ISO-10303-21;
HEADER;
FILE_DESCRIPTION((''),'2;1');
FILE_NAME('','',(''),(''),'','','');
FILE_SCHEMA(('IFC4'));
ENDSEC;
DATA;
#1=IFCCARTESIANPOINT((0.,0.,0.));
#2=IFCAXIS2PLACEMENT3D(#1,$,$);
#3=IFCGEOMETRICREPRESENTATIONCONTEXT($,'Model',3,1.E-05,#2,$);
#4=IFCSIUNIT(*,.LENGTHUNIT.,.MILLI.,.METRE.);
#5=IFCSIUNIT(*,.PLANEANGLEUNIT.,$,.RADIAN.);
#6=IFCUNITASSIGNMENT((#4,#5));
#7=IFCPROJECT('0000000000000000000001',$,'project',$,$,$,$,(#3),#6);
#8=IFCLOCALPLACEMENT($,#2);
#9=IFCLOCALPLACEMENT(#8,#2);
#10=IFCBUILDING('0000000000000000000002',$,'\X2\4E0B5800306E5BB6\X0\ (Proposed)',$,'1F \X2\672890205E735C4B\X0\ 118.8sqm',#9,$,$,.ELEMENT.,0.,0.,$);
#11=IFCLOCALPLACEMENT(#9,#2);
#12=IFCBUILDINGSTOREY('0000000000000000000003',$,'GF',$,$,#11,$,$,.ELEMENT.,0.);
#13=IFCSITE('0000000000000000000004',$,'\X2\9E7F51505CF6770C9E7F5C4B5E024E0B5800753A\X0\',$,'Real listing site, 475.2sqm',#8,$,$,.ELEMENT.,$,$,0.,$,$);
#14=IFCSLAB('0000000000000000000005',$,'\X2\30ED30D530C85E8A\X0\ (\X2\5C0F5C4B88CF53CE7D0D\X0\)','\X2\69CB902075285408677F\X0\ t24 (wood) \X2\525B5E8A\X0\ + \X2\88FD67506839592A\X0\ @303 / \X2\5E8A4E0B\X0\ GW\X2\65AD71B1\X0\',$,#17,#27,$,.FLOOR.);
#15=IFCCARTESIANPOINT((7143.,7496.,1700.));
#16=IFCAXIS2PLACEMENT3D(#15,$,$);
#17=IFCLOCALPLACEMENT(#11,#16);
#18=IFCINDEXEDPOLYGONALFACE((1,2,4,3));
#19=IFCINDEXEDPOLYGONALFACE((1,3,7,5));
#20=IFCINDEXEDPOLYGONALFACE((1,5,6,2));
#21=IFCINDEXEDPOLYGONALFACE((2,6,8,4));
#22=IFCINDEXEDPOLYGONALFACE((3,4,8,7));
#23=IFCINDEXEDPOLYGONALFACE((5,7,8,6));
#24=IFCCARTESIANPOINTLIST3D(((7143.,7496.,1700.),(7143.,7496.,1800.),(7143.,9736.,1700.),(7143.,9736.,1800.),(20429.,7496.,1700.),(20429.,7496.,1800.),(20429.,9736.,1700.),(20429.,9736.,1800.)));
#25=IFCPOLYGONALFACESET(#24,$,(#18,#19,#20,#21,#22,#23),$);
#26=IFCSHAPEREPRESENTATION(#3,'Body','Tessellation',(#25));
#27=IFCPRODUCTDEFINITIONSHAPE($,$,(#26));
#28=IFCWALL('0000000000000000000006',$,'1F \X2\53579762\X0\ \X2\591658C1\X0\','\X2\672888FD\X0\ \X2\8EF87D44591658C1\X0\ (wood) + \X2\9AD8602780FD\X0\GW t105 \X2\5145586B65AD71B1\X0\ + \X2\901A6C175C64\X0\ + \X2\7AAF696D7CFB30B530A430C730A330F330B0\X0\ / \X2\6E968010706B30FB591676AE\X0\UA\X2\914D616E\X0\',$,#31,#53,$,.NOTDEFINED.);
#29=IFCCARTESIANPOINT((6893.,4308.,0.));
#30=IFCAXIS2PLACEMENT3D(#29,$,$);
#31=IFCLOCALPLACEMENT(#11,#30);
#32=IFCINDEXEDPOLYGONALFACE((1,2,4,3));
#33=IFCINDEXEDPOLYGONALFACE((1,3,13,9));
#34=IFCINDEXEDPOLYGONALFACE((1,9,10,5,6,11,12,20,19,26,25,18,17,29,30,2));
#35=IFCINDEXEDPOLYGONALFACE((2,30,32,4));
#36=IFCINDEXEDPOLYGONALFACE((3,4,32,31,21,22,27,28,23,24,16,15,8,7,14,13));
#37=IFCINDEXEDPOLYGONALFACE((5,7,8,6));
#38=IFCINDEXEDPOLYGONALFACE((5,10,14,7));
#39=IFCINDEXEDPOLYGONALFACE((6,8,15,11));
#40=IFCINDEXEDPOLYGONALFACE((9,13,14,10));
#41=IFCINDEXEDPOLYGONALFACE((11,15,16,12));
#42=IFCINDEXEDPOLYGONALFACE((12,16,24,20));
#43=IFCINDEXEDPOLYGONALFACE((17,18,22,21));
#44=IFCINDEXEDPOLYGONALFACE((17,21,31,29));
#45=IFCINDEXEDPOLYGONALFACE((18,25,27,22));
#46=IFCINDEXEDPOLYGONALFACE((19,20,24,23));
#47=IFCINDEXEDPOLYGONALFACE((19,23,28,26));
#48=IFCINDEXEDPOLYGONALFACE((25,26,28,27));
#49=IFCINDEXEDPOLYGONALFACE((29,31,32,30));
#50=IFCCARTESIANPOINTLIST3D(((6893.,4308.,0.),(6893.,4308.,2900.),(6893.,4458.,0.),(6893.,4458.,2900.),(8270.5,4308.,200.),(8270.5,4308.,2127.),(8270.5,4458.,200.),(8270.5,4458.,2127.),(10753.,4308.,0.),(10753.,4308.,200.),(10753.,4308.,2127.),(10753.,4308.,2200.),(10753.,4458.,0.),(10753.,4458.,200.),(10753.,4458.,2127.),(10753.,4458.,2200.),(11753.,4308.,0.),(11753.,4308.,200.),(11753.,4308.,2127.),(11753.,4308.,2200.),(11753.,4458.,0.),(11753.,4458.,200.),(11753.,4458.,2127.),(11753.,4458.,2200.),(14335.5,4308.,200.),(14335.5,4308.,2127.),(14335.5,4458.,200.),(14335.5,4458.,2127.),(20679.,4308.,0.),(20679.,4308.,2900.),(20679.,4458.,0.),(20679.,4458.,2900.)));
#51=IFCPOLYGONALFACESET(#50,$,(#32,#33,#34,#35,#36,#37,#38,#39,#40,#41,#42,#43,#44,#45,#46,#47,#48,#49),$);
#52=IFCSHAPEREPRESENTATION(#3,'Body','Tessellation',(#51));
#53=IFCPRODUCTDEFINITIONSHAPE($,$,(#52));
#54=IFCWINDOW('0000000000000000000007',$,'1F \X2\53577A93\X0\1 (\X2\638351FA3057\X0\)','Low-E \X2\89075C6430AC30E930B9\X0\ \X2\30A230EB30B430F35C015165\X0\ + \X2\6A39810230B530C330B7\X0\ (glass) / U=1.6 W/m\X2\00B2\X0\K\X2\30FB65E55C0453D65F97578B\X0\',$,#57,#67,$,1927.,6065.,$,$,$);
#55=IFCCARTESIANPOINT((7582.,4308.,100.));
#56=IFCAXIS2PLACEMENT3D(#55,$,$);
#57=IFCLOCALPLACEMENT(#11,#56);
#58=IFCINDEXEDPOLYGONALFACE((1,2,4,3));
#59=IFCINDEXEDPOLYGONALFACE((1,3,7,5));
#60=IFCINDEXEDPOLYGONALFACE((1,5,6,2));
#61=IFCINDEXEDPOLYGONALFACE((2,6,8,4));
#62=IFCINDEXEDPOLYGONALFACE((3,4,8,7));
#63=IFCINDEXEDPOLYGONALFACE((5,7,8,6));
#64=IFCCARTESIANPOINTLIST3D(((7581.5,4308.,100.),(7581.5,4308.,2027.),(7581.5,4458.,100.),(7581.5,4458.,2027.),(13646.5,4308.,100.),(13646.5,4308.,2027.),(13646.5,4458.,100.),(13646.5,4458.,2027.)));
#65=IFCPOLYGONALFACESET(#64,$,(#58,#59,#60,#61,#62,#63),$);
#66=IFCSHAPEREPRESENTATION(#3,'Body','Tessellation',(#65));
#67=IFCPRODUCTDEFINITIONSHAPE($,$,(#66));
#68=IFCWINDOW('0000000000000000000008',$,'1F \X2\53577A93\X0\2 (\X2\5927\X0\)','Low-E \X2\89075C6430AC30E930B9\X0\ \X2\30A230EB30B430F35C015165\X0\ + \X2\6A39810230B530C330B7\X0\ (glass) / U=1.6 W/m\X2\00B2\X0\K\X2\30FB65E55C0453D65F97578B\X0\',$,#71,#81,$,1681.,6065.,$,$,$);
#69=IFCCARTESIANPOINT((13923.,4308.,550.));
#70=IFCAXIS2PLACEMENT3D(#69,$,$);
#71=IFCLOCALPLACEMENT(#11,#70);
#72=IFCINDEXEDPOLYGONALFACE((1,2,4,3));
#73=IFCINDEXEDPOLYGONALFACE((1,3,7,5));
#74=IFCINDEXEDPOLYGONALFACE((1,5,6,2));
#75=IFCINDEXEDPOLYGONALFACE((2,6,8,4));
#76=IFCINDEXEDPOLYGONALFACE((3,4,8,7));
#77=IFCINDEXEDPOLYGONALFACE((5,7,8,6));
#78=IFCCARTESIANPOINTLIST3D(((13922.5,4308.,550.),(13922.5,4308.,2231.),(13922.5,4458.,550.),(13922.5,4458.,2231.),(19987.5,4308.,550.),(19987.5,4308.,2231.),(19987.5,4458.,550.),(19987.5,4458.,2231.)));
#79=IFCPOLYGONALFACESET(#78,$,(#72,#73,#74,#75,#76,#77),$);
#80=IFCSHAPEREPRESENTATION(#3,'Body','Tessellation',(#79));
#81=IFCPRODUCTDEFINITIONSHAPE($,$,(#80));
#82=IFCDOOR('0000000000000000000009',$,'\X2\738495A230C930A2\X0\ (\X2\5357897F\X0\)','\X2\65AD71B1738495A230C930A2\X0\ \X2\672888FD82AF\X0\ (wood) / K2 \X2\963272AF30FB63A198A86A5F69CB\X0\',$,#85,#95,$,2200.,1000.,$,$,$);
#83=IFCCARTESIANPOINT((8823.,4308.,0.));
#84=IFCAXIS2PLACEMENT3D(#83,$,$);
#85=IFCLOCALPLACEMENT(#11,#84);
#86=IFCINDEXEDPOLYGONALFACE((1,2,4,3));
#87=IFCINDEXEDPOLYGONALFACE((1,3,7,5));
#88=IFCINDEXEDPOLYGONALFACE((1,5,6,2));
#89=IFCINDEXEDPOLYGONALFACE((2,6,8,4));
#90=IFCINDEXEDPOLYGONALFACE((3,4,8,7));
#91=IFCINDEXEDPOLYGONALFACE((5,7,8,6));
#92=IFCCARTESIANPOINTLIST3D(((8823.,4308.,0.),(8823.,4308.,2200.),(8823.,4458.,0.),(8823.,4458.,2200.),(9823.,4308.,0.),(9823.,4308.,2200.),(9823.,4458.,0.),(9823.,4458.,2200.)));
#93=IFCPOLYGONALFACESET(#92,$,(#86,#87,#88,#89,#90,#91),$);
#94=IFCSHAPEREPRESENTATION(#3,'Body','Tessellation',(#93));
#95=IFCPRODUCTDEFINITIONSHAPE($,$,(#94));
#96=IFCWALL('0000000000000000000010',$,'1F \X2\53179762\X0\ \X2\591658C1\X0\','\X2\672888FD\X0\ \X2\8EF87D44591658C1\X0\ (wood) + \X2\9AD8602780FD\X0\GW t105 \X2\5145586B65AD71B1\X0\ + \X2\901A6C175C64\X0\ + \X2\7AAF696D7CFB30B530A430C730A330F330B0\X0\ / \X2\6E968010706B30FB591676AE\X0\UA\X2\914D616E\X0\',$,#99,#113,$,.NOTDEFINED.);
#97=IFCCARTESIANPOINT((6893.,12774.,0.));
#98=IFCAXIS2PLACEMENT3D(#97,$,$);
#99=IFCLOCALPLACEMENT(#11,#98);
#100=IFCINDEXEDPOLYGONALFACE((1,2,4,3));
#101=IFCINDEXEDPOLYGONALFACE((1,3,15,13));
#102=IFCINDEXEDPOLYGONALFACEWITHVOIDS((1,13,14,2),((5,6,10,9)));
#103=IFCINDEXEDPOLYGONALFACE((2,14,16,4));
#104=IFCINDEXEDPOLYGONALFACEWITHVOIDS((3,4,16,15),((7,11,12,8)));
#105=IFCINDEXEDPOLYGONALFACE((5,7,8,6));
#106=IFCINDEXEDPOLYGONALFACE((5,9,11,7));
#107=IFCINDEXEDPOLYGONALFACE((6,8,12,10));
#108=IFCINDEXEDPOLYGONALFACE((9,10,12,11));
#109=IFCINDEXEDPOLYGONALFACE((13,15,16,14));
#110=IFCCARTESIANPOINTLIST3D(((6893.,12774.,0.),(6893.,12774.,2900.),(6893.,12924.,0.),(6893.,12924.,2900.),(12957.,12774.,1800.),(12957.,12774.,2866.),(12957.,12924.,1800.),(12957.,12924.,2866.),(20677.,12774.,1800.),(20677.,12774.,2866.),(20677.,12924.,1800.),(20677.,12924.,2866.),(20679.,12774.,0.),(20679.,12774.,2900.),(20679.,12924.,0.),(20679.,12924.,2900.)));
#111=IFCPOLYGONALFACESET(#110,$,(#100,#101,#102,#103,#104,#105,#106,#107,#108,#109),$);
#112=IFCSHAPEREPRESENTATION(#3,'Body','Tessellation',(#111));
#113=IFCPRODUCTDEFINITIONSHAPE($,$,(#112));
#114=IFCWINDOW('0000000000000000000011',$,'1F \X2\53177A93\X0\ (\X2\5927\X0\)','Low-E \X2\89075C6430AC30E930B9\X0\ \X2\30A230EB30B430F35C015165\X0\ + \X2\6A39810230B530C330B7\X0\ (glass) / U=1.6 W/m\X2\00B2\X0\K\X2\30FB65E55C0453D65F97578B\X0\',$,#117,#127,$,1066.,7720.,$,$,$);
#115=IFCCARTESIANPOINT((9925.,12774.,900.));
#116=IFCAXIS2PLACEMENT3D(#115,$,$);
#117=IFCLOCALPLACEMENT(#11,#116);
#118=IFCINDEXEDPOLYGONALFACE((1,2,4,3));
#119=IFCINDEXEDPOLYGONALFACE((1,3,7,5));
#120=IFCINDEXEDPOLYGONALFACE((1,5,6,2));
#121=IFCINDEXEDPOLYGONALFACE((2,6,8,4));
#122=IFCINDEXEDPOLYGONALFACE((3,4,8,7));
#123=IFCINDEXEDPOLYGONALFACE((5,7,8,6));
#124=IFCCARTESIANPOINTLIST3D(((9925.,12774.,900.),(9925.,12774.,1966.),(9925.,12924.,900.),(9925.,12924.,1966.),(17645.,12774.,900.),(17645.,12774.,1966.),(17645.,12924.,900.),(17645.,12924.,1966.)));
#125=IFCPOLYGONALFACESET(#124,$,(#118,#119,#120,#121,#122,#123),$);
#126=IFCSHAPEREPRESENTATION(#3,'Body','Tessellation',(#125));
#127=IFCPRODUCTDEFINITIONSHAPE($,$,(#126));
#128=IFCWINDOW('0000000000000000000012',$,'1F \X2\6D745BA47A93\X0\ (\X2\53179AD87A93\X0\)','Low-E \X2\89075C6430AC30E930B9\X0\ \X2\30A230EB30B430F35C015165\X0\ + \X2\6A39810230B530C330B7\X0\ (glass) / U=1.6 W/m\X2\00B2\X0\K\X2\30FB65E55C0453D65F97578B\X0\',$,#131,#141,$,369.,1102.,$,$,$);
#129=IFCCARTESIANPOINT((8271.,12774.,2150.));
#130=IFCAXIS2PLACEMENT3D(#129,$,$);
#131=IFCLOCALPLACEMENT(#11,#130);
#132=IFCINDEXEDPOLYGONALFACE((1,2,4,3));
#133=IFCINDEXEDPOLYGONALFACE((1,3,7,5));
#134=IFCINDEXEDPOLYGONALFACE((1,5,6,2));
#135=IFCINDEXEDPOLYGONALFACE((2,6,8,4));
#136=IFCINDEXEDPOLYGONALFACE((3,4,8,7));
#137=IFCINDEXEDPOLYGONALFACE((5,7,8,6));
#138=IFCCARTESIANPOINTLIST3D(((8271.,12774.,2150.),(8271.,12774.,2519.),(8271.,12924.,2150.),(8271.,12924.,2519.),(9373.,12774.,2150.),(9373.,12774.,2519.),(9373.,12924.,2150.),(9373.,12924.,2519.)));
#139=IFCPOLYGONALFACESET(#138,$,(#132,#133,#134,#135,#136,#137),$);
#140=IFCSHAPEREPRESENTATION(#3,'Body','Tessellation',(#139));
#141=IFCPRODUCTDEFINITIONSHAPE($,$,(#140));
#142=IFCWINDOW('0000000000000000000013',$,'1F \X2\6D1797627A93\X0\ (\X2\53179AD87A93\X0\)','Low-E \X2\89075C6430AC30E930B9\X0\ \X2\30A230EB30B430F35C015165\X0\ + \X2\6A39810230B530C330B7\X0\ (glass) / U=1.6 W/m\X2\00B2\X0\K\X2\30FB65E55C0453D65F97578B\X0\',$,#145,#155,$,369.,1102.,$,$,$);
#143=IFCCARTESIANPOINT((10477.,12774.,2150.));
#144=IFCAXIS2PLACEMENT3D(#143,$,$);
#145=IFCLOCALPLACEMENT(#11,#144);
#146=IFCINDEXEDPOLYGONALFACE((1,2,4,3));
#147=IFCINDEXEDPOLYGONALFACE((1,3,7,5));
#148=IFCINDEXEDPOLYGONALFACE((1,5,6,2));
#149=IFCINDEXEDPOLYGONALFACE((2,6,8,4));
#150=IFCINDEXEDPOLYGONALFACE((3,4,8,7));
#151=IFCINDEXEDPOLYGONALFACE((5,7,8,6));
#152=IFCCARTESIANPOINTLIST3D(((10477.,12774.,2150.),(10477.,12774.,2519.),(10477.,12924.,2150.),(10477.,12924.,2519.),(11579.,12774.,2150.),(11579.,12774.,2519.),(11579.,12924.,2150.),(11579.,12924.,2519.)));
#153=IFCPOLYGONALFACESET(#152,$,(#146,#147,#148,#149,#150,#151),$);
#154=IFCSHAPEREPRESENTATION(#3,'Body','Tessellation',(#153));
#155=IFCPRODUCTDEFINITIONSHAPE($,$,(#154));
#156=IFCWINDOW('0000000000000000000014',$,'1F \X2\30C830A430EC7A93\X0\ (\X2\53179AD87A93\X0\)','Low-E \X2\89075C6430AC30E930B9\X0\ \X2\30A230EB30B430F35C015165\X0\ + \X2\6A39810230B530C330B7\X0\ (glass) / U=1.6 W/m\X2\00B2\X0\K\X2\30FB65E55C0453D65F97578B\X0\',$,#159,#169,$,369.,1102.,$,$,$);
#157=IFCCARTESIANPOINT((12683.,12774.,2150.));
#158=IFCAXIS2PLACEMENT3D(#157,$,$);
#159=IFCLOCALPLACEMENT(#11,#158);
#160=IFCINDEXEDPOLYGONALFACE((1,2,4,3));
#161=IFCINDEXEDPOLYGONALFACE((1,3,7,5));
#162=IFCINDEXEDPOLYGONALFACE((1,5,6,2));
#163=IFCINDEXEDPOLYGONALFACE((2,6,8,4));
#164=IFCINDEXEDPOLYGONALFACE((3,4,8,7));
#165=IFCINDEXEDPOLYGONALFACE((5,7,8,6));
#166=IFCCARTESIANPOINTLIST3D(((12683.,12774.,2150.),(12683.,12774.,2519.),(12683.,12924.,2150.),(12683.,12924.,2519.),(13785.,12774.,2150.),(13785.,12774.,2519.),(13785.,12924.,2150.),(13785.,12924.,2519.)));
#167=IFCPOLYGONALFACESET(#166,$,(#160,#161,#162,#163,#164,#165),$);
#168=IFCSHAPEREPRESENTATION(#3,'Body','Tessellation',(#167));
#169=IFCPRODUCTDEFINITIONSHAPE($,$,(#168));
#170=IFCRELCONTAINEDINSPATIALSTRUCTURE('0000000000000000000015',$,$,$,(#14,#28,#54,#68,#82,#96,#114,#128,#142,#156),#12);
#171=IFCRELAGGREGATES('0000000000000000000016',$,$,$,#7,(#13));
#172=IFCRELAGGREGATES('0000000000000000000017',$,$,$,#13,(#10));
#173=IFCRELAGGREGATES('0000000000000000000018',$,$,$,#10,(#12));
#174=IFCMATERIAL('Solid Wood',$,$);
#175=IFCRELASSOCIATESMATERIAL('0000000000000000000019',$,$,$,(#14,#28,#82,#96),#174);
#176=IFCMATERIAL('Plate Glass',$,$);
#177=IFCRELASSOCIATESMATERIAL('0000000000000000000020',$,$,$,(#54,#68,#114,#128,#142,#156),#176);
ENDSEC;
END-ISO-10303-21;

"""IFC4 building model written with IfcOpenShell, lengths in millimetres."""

from ifc_helpers import new_model, si_unit, frame, frame_2d, origin, place, context, project, spatial, rectangle, extrude, material, element, fill, save


model = new_model("IFC4")

# Units and contexts
model_context = context("Model", 3, precision=1e-05, world=origin())
ifc_project = project(units=[si_unit("LENGTHUNIT", "METRE", prefix="MILLI"), si_unit("PLANEANGLEUNIT", "RADIAN")], contexts=[model_context])

# Site, building, storey
site_placement = place(None, origin())
site = spatial("IfcSite", under=ifc_project, at=site_placement, Name="鹿児島県鹿屋市下堀町", ObjectType="Real listing site, 475.2sqm", CompositionType="ELEMENT", RefElevation=0.0)
building_placement = place(site_placement, origin())
building = spatial("IfcBuilding", under=site, at=building_placement, Name="下堀の家 (Proposed)", ObjectType="1F 木造平屋 118.8sqm", CompositionType="ELEMENT", ElevationOfRefHeight=0.0, ElevationOfTerrain=0.0)
storey_placement = place(building_placement, origin())
storey = spatial("IfcBuildingStorey", under=building, at=storey_placement, Name="GF", CompositionType="ELEMENT", Elevation=0.0)

# Slab
ifc_material_1 = material(Name="Solid Wood")
slab_1_placement = place(storey_placement, frame((7143.0, 7496.0, 1700.0)))
element("IfcSlab", 1, at=slab_1_placement, inside=storey, material=ifc_material_1, Name="ロフト床 (小屋裏収納)", Description="構造用合板 t24 (wood) 剛床 + 製材根太 @303 / 床下 GW断熱", PredefinedType="FLOOR", context=model_context, shape_type="SweptSolid", body=[
    extrude(rectangle(XDim=13286.0, YDim=2240.0, at=frame_2d((6643.0, 1120.0))), frame((7143.0, 7496.0, 1700.0)), (0.0, 0.0, 1.0), 100.0),
])

# Wall, openings, windows, door
wall_1_placement = place(storey_placement, frame((6893.0, 4308.0, 0.0)))
wall_1 = element("IfcWall", 2, at=wall_1_placement, inside=storey, material=ifc_material_1, Name="1F 南面 外壁", Description="木製 軸組外壁 (wood) + 高性能GW t105 充填断熱 + 通気層 + 窯業系サイディング / 準耐火・外皮UA配慮", PredefinedType="NOTDEFINED", context=model_context, shape_type="SweptSolid", body=[
    extrude(rectangle(XDim=13786.0, YDim=150.0, at=frame_2d((6893.0, 75.0))), frame((6893.0, 4308.0, 0.0)), (0.0, 0.0, 1.0), 2900.0),
])
opening_1_placement = place(storey_placement, frame((7582.0, 4308.0, 100.0)))
opening_1 = element("IfcOpeningElement", 3, at=opening_1_placement, cuts=wall_1, PredefinedType="NOTDEFINED", context=model_context, shape_type="SweptSolid", body=[
    extrude(rectangle(XDim=6065.0, YDim=150.0, at=frame_2d((3032.0, 75.0))), frame((7582.0, 4308.0, 100.0)), (0.0, 0.0, 1.0), 1927.0),
])
opening_2_placement = place(storey_placement, frame((13923.0, 4308.0, 550.0)))
opening_2 = element("IfcOpeningElement", 4, at=opening_2_placement, cuts=wall_1, PredefinedType="NOTDEFINED", context=model_context, shape_type="SweptSolid", body=[
    extrude(rectangle(XDim=6065.0, YDim=150.0, at=frame_2d((3032.0, 75.0))), frame((13923.0, 4308.0, 550.0)), (0.0, 0.0, 1.0), 1681.0),
])
opening_3_placement = place(storey_placement, frame((8823.0, 4308.0, 0.0)))
opening_3 = element("IfcOpeningElement", 5, at=opening_3_placement, cuts=wall_1, PredefinedType="NOTDEFINED", context=model_context, shape_type="SweptSolid", body=[
    extrude(rectangle(XDim=1000.0, YDim=150.0, at=frame_2d((500.0, 75.0))), frame((8823.0, 4308.0, 0.0)), (0.0, 0.0, 1.0), 2200.0),
])
ifc_material_2 = material(Name="Plate Glass")
window_1_placement = place(storey_placement, frame((7582.0, 4308.0, 100.0)))
window_1 = element("IfcWindow", 6, at=window_1_placement, inside=storey, material=ifc_material_2, Name="1F 南窓1 (掃出し)", Description="Low-E 複層ガラス アルゴン封入 + 樹脂サッシ (glass) / U=1.6 W/m²K・日射取得型", OverallHeight=1927.0, OverallWidth=6065.0, context=model_context, shape_type="SweptSolid", body=[
    extrude(rectangle(XDim=6065.0, YDim=150.0, at=frame_2d((3032.0, 75.0))), frame((7582.0, 4308.0, 100.0)), (0.0, 0.0, 1.0), 1927.0),
])
fill(opening_1, window_1)
window_2_placement = place(storey_placement, frame((13923.0, 4308.0, 550.0)))
window_2 = element("IfcWindow", 7, at=window_2_placement, inside=storey, material=ifc_material_2, Name="1F 南窓2 (大)", Description="Low-E 複層ガラス アルゴン封入 + 樹脂サッシ (glass) / U=1.6 W/m²K・日射取得型", OverallHeight=1681.0, OverallWidth=6065.0, context=model_context, shape_type="SweptSolid", body=[
    extrude(rectangle(XDim=6065.0, YDim=150.0, at=frame_2d((3032.0, 75.0))), frame((13923.0, 4308.0, 550.0)), (0.0, 0.0, 1.0), 1681.0),
])
fill(opening_2, window_2)
door_1_placement = place(storey_placement, frame((8823.0, 4308.0, 0.0)))
door_1 = element("IfcDoor", 8, at=door_1_placement, inside=storey, material=ifc_material_1, Name="玄関ドア (南西)", Description="断熱玄関ドア 木製芯 (wood) / K2 防犯・採風機構", OverallHeight=2200.0, OverallWidth=1000.0, context=model_context, shape_type="SweptSolid", body=[
    extrude(rectangle(XDim=1000.0, YDim=150.0, at=frame_2d((500.0, 75.0))), frame((8823.0, 4308.0, 0.0)), (0.0, 0.0, 1.0), 2200.0),
])
fill(opening_3, door_1)

# Wall, openings, windows
wall_2_placement = place(storey_placement, frame((6893.0, 12774.0, 0.0)))
wall_2 = element("IfcWall", 9, at=wall_2_placement, inside=storey, material=ifc_material_1, Name="1F 北面 外壁", Description="木製 軸組外壁 (wood) + 高性能GW t105 充填断熱 + 通気層 + 窯業系サイディング / 準耐火・外皮UA配慮", PredefinedType="NOTDEFINED", context=model_context, shape_type="SweptSolid", body=[
    extrude(rectangle(XDim=13786.0, YDim=150.0, at=frame_2d((6893.0, 75.0))), frame((6893.0, 12774.0, 0.0)), (0.0, 0.0, 1.0), 2900.0),
])
opening_4_placement = place(storey_placement, frame((9925.0, 12774.0, 900.0)))
opening_4 = element("IfcOpeningElement", 10, at=opening_4_placement, cuts=wall_2, PredefinedType="NOTDEFINED", context=model_context, shape_type="SweptSolid", body=[
    extrude(rectangle(XDim=7720.0, YDim=150.0, at=frame_2d((3860.0, 75.0))), frame((9925.0, 12774.0, 900.0)), (0.0, 0.0, 1.0), 1066.0),
])
opening_5_placement = place(storey_placement, frame((8271.0, 12774.0, 2150.0)))
opening_5 = element("IfcOpeningElement", 11, at=opening_5_placement, cuts=wall_2, PredefinedType="NOTDEFINED", context=model_context, shape_type="SweptSolid", body=[
    extrude(rectangle(XDim=1102.0, YDim=150.0, at=frame_2d((551.0, 75.0))), frame((8271.0, 12774.0, 2150.0)), (0.0, 0.0, 1.0), 369.0),
])
opening_6_placement = place(storey_placement, frame((10477.0, 12774.0, 2150.0)))
opening_6 = element("IfcOpeningElement", 12, at=opening_6_placement, cuts=wall_2, PredefinedType="NOTDEFINED", context=model_context, shape_type="SweptSolid", body=[
    extrude(rectangle(XDim=1102.0, YDim=150.0, at=frame_2d((551.0, 75.0))), frame((10477.0, 12774.0, 2150.0)), (0.0, 0.0, 1.0), 369.0),
])
opening_7_placement = place(storey_placement, frame((12683.0, 12774.0, 2150.0)))
opening_7 = element("IfcOpeningElement", 13, at=opening_7_placement, cuts=wall_2, PredefinedType="NOTDEFINED", context=model_context, shape_type="SweptSolid", body=[
    extrude(rectangle(XDim=1102.0, YDim=150.0, at=frame_2d((551.0, 75.0))), frame((12683.0, 12774.0, 2150.0)), (0.0, 0.0, 1.0), 369.0),
])
window_3_placement = place(storey_placement, frame((9925.0, 12774.0, 900.0)))
window_3 = element("IfcWindow", 14, at=window_3_placement, inside=storey, material=ifc_material_2, Name="1F 北窓 (大)", Description="Low-E 複層ガラス アルゴン封入 + 樹脂サッシ (glass) / U=1.6 W/m²K・日射取得型", OverallHeight=1066.0, OverallWidth=7720.0, context=model_context, shape_type="SweptSolid", body=[
    extrude(rectangle(XDim=7720.0, YDim=150.0, at=frame_2d((3860.0, 75.0))), frame((9925.0, 12774.0, 900.0)), (0.0, 0.0, 1.0), 1066.0),
])
fill(opening_4, window_3)
window_4_placement = place(storey_placement, frame((8271.0, 12774.0, 2150.0)))
window_4 = element("IfcWindow", 15, at=window_4_placement, inside=storey, material=ifc_material_2, Name="1F 浴室窓 (北高窓)", Description="Low-E 複層ガラス アルゴン封入 + 樹脂サッシ (glass) / U=1.6 W/m²K・日射取得型", OverallHeight=369.0, OverallWidth=1102.0, context=model_context, shape_type="SweptSolid", body=[
    extrude(rectangle(XDim=1102.0, YDim=150.0, at=frame_2d((551.0, 75.0))), frame((8271.0, 12774.0, 2150.0)), (0.0, 0.0, 1.0), 369.0),
])
fill(opening_5, window_4)
window_5_placement = place(storey_placement, frame((10477.0, 12774.0, 2150.0)))
window_5 = element("IfcWindow", 16, at=window_5_placement, inside=storey, material=ifc_material_2, Name="1F 洗面窓 (北高窓)", Description="Low-E 複層ガラス アルゴン封入 + 樹脂サッシ (glass) / U=1.6 W/m²K・日射取得型", OverallHeight=369.0, OverallWidth=1102.0, context=model_context, shape_type="SweptSolid", body=[
    extrude(rectangle(XDim=1102.0, YDim=150.0, at=frame_2d((551.0, 75.0))), frame((10477.0, 12774.0, 2150.0)), (0.0, 0.0, 1.0), 369.0),
])
fill(opening_6, window_5)
window_6_placement = place(storey_placement, frame((12683.0, 12774.0, 2150.0)))
window_6 = element("IfcWindow", 17, at=window_6_placement, inside=storey, material=ifc_material_2, Name="1F トイレ窓 (北高窓)", Description="Low-E 複層ガラス アルゴン封入 + 樹脂サッシ (glass) / U=1.6 W/m²K・日射取得型", OverallHeight=369.0, OverallWidth=1102.0, context=model_context, shape_type="SweptSolid", body=[
    extrude(rectangle(XDim=1102.0, YDim=150.0, at=frame_2d((551.0, 75.0))), frame((12683.0, 12774.0, 2150.0)), (0.0, 0.0, 1.0), 369.0),
])
fill(opening_7, window_6)

save(model, "model.ifc")
